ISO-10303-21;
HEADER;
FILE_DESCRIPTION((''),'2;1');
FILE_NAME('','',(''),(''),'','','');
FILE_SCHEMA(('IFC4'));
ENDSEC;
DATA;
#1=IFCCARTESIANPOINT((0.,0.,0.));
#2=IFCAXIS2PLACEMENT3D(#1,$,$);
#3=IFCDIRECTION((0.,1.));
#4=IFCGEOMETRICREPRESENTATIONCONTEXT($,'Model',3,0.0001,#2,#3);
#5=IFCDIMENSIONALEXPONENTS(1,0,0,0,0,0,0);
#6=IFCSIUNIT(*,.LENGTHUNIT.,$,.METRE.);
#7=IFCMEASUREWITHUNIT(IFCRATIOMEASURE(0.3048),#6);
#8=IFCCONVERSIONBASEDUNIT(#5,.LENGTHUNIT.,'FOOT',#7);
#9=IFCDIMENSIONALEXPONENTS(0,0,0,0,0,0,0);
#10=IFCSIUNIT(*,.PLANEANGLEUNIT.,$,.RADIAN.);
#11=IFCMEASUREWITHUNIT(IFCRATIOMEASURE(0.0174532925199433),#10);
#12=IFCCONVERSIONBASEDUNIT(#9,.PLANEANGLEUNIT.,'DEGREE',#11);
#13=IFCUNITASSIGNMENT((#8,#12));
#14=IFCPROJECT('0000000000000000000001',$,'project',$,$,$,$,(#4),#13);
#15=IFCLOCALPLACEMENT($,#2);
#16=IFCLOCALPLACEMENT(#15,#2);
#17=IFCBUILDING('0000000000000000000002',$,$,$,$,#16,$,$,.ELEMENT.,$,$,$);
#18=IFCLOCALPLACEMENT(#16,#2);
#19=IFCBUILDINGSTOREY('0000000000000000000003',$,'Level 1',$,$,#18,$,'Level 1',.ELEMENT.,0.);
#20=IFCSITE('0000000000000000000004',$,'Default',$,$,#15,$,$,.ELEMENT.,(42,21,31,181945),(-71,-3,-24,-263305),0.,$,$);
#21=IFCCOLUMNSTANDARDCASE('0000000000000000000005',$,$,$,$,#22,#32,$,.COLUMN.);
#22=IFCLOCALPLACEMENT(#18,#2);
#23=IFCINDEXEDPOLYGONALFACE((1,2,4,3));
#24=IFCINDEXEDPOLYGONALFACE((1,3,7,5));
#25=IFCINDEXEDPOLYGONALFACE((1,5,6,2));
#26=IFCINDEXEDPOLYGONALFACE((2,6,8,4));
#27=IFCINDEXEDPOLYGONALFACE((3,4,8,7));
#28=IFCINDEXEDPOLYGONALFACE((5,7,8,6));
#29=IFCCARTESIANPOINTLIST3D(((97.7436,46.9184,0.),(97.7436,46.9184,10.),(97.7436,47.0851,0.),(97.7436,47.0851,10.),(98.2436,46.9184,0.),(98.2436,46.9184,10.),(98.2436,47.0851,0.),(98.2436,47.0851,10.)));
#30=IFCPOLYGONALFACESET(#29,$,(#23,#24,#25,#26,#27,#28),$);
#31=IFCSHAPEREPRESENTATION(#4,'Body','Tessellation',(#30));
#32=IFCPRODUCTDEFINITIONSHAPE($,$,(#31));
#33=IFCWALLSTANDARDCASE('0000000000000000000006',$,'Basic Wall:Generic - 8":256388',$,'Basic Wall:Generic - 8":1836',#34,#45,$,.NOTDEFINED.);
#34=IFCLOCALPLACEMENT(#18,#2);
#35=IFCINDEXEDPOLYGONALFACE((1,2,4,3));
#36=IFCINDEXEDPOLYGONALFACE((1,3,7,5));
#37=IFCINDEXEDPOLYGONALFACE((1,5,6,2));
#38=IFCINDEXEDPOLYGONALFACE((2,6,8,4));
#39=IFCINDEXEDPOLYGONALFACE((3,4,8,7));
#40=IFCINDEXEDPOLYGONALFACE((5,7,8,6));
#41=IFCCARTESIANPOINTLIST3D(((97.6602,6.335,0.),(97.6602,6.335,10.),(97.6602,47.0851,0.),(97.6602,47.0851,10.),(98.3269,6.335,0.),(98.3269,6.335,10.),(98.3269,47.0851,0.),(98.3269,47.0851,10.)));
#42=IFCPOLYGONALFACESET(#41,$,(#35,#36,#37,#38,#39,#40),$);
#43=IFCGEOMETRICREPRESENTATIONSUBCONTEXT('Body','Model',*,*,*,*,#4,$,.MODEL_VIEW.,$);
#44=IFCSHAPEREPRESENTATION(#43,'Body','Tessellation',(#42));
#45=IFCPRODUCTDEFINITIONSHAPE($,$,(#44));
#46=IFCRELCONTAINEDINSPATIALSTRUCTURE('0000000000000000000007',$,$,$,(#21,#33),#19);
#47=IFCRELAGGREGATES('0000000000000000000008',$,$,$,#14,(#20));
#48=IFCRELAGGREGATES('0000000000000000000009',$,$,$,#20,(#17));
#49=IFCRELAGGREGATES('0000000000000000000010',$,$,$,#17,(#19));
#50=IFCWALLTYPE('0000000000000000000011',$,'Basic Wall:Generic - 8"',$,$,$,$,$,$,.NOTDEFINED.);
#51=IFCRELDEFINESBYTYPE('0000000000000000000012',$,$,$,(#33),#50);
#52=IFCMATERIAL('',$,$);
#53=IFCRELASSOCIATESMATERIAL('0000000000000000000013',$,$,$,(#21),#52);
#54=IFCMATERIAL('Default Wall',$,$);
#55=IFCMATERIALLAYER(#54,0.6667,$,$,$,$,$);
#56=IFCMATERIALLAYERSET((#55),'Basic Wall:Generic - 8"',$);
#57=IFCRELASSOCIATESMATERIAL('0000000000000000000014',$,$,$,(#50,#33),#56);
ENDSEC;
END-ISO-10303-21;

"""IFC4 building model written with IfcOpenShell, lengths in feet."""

from ifc_helpers import new_model, entity, si_unit, converted_unit, direction, frame, frame_2d, origin, place, context, subcontext, project, spatial, rectangle, extrude, material, layer, layer_set, layer_usage, type_object, element, save


model = new_model("IFC4")

# Units and contexts
model_context = context("Model", 3, precision=0.0001, world=origin(), true_north=direction((0.0, 1.0)))
body_context = subcontext(model_context, "Body", "Model", "MODEL_VIEW")
ifc_project = project(units=[converted_unit("LENGTHUNIT", "FOOT", entity("IfcRatioMeasure", 0.3048), si_unit("LENGTHUNIT", "METRE"), dimensions=[1, 0, 0, 0, 0, 0, 0]), converted_unit("PLANEANGLEUNIT", "DEGREE", entity("IfcRatioMeasure", 0.0174532925199433), si_unit("PLANEANGLEUNIT", "RADIAN"), dimensions=[0, 0, 0, 0, 0, 0, 0])], contexts=[model_context])

# Site, building, storey
site_placement = place(None, origin())
site = spatial("IfcSite", under=ifc_project, at=site_placement, Name="Default", CompositionType="ELEMENT", RefLatitude=(42, 21, 31, 181945), RefLongitude=(-71, -3, -24, -263305), RefElevation=0.0)
building_placement = place(site_placement, origin())
building = spatial("IfcBuilding", under=site, at=building_placement, CompositionType="ELEMENT")
storey_placement = place(building_placement, origin())
storey = spatial("IfcBuildingStorey", under=building, at=storey_placement, Name="Level 1", LongName="Level 1", CompositionType="ELEMENT", Elevation=0.0)

# Column
ifc_material_1 = material(Name="")
wall_placement = place(storey_placement, frame((97.9936, 47.0851, 0.0), z_axis=(0.0, 0.0, 1.0), x_axis=(0.0, -1.0, 0.0)))
for number, where, z_axis, x_axis in (
    (1, (0.0833, 0.0, 0.0), (0.0, 0.0, 1.0), (1.0, 0.0, 0.0)),
):
    element("IfcColumnStandardCase", number, at=place(wall_placement, frame(where, z_axis=z_axis, x_axis=x_axis)), inside=storey, material=ifc_material_1, PredefinedType="COLUMN", context=model_context, shape_type="SweptSolid", body=[
        extrude(rectangle(XDim=0.1667, YDim=0.5), origin(), (0.0, 0.0, 1.0), 10.0),
    ])

# Wall
ifc_material_2 = material(Name="Default Wall")
ifc_layer = layer(ifc_material_2, 0.6667)
ifc_layer_set = layer_set([ifc_layer], Name="Basic Wall:Generic - 8\"")
ifc_layer_usage = layer_usage(ifc_layer_set, "AXIS2", "NEGATIVE", 0.3333)
wall_type = type_object("IfcWallType", Name="Basic Wall:Generic - 8\"", PredefinedType="NOTDEFINED", material=ifc_layer_set)
element("IfcWallStandardCase", 2, at=wall_placement, inside=storey, type_object=wall_type, material=ifc_layer_usage, Name="Basic Wall:Generic - 8\":256388", ObjectType="Basic Wall:Generic - 8\":1836", PredefinedType="NOTDEFINED", context=body_context, shape_type="SweptSolid", body=[
    extrude(rectangle(XDim=40.7501, YDim=0.6667, at=frame_2d((20.375, 0.0), x_axis=(-1.0, 0.0))), origin(), (0.0, 0.0, 1.0), 10.0),
])

save(model, "model.ifc")
